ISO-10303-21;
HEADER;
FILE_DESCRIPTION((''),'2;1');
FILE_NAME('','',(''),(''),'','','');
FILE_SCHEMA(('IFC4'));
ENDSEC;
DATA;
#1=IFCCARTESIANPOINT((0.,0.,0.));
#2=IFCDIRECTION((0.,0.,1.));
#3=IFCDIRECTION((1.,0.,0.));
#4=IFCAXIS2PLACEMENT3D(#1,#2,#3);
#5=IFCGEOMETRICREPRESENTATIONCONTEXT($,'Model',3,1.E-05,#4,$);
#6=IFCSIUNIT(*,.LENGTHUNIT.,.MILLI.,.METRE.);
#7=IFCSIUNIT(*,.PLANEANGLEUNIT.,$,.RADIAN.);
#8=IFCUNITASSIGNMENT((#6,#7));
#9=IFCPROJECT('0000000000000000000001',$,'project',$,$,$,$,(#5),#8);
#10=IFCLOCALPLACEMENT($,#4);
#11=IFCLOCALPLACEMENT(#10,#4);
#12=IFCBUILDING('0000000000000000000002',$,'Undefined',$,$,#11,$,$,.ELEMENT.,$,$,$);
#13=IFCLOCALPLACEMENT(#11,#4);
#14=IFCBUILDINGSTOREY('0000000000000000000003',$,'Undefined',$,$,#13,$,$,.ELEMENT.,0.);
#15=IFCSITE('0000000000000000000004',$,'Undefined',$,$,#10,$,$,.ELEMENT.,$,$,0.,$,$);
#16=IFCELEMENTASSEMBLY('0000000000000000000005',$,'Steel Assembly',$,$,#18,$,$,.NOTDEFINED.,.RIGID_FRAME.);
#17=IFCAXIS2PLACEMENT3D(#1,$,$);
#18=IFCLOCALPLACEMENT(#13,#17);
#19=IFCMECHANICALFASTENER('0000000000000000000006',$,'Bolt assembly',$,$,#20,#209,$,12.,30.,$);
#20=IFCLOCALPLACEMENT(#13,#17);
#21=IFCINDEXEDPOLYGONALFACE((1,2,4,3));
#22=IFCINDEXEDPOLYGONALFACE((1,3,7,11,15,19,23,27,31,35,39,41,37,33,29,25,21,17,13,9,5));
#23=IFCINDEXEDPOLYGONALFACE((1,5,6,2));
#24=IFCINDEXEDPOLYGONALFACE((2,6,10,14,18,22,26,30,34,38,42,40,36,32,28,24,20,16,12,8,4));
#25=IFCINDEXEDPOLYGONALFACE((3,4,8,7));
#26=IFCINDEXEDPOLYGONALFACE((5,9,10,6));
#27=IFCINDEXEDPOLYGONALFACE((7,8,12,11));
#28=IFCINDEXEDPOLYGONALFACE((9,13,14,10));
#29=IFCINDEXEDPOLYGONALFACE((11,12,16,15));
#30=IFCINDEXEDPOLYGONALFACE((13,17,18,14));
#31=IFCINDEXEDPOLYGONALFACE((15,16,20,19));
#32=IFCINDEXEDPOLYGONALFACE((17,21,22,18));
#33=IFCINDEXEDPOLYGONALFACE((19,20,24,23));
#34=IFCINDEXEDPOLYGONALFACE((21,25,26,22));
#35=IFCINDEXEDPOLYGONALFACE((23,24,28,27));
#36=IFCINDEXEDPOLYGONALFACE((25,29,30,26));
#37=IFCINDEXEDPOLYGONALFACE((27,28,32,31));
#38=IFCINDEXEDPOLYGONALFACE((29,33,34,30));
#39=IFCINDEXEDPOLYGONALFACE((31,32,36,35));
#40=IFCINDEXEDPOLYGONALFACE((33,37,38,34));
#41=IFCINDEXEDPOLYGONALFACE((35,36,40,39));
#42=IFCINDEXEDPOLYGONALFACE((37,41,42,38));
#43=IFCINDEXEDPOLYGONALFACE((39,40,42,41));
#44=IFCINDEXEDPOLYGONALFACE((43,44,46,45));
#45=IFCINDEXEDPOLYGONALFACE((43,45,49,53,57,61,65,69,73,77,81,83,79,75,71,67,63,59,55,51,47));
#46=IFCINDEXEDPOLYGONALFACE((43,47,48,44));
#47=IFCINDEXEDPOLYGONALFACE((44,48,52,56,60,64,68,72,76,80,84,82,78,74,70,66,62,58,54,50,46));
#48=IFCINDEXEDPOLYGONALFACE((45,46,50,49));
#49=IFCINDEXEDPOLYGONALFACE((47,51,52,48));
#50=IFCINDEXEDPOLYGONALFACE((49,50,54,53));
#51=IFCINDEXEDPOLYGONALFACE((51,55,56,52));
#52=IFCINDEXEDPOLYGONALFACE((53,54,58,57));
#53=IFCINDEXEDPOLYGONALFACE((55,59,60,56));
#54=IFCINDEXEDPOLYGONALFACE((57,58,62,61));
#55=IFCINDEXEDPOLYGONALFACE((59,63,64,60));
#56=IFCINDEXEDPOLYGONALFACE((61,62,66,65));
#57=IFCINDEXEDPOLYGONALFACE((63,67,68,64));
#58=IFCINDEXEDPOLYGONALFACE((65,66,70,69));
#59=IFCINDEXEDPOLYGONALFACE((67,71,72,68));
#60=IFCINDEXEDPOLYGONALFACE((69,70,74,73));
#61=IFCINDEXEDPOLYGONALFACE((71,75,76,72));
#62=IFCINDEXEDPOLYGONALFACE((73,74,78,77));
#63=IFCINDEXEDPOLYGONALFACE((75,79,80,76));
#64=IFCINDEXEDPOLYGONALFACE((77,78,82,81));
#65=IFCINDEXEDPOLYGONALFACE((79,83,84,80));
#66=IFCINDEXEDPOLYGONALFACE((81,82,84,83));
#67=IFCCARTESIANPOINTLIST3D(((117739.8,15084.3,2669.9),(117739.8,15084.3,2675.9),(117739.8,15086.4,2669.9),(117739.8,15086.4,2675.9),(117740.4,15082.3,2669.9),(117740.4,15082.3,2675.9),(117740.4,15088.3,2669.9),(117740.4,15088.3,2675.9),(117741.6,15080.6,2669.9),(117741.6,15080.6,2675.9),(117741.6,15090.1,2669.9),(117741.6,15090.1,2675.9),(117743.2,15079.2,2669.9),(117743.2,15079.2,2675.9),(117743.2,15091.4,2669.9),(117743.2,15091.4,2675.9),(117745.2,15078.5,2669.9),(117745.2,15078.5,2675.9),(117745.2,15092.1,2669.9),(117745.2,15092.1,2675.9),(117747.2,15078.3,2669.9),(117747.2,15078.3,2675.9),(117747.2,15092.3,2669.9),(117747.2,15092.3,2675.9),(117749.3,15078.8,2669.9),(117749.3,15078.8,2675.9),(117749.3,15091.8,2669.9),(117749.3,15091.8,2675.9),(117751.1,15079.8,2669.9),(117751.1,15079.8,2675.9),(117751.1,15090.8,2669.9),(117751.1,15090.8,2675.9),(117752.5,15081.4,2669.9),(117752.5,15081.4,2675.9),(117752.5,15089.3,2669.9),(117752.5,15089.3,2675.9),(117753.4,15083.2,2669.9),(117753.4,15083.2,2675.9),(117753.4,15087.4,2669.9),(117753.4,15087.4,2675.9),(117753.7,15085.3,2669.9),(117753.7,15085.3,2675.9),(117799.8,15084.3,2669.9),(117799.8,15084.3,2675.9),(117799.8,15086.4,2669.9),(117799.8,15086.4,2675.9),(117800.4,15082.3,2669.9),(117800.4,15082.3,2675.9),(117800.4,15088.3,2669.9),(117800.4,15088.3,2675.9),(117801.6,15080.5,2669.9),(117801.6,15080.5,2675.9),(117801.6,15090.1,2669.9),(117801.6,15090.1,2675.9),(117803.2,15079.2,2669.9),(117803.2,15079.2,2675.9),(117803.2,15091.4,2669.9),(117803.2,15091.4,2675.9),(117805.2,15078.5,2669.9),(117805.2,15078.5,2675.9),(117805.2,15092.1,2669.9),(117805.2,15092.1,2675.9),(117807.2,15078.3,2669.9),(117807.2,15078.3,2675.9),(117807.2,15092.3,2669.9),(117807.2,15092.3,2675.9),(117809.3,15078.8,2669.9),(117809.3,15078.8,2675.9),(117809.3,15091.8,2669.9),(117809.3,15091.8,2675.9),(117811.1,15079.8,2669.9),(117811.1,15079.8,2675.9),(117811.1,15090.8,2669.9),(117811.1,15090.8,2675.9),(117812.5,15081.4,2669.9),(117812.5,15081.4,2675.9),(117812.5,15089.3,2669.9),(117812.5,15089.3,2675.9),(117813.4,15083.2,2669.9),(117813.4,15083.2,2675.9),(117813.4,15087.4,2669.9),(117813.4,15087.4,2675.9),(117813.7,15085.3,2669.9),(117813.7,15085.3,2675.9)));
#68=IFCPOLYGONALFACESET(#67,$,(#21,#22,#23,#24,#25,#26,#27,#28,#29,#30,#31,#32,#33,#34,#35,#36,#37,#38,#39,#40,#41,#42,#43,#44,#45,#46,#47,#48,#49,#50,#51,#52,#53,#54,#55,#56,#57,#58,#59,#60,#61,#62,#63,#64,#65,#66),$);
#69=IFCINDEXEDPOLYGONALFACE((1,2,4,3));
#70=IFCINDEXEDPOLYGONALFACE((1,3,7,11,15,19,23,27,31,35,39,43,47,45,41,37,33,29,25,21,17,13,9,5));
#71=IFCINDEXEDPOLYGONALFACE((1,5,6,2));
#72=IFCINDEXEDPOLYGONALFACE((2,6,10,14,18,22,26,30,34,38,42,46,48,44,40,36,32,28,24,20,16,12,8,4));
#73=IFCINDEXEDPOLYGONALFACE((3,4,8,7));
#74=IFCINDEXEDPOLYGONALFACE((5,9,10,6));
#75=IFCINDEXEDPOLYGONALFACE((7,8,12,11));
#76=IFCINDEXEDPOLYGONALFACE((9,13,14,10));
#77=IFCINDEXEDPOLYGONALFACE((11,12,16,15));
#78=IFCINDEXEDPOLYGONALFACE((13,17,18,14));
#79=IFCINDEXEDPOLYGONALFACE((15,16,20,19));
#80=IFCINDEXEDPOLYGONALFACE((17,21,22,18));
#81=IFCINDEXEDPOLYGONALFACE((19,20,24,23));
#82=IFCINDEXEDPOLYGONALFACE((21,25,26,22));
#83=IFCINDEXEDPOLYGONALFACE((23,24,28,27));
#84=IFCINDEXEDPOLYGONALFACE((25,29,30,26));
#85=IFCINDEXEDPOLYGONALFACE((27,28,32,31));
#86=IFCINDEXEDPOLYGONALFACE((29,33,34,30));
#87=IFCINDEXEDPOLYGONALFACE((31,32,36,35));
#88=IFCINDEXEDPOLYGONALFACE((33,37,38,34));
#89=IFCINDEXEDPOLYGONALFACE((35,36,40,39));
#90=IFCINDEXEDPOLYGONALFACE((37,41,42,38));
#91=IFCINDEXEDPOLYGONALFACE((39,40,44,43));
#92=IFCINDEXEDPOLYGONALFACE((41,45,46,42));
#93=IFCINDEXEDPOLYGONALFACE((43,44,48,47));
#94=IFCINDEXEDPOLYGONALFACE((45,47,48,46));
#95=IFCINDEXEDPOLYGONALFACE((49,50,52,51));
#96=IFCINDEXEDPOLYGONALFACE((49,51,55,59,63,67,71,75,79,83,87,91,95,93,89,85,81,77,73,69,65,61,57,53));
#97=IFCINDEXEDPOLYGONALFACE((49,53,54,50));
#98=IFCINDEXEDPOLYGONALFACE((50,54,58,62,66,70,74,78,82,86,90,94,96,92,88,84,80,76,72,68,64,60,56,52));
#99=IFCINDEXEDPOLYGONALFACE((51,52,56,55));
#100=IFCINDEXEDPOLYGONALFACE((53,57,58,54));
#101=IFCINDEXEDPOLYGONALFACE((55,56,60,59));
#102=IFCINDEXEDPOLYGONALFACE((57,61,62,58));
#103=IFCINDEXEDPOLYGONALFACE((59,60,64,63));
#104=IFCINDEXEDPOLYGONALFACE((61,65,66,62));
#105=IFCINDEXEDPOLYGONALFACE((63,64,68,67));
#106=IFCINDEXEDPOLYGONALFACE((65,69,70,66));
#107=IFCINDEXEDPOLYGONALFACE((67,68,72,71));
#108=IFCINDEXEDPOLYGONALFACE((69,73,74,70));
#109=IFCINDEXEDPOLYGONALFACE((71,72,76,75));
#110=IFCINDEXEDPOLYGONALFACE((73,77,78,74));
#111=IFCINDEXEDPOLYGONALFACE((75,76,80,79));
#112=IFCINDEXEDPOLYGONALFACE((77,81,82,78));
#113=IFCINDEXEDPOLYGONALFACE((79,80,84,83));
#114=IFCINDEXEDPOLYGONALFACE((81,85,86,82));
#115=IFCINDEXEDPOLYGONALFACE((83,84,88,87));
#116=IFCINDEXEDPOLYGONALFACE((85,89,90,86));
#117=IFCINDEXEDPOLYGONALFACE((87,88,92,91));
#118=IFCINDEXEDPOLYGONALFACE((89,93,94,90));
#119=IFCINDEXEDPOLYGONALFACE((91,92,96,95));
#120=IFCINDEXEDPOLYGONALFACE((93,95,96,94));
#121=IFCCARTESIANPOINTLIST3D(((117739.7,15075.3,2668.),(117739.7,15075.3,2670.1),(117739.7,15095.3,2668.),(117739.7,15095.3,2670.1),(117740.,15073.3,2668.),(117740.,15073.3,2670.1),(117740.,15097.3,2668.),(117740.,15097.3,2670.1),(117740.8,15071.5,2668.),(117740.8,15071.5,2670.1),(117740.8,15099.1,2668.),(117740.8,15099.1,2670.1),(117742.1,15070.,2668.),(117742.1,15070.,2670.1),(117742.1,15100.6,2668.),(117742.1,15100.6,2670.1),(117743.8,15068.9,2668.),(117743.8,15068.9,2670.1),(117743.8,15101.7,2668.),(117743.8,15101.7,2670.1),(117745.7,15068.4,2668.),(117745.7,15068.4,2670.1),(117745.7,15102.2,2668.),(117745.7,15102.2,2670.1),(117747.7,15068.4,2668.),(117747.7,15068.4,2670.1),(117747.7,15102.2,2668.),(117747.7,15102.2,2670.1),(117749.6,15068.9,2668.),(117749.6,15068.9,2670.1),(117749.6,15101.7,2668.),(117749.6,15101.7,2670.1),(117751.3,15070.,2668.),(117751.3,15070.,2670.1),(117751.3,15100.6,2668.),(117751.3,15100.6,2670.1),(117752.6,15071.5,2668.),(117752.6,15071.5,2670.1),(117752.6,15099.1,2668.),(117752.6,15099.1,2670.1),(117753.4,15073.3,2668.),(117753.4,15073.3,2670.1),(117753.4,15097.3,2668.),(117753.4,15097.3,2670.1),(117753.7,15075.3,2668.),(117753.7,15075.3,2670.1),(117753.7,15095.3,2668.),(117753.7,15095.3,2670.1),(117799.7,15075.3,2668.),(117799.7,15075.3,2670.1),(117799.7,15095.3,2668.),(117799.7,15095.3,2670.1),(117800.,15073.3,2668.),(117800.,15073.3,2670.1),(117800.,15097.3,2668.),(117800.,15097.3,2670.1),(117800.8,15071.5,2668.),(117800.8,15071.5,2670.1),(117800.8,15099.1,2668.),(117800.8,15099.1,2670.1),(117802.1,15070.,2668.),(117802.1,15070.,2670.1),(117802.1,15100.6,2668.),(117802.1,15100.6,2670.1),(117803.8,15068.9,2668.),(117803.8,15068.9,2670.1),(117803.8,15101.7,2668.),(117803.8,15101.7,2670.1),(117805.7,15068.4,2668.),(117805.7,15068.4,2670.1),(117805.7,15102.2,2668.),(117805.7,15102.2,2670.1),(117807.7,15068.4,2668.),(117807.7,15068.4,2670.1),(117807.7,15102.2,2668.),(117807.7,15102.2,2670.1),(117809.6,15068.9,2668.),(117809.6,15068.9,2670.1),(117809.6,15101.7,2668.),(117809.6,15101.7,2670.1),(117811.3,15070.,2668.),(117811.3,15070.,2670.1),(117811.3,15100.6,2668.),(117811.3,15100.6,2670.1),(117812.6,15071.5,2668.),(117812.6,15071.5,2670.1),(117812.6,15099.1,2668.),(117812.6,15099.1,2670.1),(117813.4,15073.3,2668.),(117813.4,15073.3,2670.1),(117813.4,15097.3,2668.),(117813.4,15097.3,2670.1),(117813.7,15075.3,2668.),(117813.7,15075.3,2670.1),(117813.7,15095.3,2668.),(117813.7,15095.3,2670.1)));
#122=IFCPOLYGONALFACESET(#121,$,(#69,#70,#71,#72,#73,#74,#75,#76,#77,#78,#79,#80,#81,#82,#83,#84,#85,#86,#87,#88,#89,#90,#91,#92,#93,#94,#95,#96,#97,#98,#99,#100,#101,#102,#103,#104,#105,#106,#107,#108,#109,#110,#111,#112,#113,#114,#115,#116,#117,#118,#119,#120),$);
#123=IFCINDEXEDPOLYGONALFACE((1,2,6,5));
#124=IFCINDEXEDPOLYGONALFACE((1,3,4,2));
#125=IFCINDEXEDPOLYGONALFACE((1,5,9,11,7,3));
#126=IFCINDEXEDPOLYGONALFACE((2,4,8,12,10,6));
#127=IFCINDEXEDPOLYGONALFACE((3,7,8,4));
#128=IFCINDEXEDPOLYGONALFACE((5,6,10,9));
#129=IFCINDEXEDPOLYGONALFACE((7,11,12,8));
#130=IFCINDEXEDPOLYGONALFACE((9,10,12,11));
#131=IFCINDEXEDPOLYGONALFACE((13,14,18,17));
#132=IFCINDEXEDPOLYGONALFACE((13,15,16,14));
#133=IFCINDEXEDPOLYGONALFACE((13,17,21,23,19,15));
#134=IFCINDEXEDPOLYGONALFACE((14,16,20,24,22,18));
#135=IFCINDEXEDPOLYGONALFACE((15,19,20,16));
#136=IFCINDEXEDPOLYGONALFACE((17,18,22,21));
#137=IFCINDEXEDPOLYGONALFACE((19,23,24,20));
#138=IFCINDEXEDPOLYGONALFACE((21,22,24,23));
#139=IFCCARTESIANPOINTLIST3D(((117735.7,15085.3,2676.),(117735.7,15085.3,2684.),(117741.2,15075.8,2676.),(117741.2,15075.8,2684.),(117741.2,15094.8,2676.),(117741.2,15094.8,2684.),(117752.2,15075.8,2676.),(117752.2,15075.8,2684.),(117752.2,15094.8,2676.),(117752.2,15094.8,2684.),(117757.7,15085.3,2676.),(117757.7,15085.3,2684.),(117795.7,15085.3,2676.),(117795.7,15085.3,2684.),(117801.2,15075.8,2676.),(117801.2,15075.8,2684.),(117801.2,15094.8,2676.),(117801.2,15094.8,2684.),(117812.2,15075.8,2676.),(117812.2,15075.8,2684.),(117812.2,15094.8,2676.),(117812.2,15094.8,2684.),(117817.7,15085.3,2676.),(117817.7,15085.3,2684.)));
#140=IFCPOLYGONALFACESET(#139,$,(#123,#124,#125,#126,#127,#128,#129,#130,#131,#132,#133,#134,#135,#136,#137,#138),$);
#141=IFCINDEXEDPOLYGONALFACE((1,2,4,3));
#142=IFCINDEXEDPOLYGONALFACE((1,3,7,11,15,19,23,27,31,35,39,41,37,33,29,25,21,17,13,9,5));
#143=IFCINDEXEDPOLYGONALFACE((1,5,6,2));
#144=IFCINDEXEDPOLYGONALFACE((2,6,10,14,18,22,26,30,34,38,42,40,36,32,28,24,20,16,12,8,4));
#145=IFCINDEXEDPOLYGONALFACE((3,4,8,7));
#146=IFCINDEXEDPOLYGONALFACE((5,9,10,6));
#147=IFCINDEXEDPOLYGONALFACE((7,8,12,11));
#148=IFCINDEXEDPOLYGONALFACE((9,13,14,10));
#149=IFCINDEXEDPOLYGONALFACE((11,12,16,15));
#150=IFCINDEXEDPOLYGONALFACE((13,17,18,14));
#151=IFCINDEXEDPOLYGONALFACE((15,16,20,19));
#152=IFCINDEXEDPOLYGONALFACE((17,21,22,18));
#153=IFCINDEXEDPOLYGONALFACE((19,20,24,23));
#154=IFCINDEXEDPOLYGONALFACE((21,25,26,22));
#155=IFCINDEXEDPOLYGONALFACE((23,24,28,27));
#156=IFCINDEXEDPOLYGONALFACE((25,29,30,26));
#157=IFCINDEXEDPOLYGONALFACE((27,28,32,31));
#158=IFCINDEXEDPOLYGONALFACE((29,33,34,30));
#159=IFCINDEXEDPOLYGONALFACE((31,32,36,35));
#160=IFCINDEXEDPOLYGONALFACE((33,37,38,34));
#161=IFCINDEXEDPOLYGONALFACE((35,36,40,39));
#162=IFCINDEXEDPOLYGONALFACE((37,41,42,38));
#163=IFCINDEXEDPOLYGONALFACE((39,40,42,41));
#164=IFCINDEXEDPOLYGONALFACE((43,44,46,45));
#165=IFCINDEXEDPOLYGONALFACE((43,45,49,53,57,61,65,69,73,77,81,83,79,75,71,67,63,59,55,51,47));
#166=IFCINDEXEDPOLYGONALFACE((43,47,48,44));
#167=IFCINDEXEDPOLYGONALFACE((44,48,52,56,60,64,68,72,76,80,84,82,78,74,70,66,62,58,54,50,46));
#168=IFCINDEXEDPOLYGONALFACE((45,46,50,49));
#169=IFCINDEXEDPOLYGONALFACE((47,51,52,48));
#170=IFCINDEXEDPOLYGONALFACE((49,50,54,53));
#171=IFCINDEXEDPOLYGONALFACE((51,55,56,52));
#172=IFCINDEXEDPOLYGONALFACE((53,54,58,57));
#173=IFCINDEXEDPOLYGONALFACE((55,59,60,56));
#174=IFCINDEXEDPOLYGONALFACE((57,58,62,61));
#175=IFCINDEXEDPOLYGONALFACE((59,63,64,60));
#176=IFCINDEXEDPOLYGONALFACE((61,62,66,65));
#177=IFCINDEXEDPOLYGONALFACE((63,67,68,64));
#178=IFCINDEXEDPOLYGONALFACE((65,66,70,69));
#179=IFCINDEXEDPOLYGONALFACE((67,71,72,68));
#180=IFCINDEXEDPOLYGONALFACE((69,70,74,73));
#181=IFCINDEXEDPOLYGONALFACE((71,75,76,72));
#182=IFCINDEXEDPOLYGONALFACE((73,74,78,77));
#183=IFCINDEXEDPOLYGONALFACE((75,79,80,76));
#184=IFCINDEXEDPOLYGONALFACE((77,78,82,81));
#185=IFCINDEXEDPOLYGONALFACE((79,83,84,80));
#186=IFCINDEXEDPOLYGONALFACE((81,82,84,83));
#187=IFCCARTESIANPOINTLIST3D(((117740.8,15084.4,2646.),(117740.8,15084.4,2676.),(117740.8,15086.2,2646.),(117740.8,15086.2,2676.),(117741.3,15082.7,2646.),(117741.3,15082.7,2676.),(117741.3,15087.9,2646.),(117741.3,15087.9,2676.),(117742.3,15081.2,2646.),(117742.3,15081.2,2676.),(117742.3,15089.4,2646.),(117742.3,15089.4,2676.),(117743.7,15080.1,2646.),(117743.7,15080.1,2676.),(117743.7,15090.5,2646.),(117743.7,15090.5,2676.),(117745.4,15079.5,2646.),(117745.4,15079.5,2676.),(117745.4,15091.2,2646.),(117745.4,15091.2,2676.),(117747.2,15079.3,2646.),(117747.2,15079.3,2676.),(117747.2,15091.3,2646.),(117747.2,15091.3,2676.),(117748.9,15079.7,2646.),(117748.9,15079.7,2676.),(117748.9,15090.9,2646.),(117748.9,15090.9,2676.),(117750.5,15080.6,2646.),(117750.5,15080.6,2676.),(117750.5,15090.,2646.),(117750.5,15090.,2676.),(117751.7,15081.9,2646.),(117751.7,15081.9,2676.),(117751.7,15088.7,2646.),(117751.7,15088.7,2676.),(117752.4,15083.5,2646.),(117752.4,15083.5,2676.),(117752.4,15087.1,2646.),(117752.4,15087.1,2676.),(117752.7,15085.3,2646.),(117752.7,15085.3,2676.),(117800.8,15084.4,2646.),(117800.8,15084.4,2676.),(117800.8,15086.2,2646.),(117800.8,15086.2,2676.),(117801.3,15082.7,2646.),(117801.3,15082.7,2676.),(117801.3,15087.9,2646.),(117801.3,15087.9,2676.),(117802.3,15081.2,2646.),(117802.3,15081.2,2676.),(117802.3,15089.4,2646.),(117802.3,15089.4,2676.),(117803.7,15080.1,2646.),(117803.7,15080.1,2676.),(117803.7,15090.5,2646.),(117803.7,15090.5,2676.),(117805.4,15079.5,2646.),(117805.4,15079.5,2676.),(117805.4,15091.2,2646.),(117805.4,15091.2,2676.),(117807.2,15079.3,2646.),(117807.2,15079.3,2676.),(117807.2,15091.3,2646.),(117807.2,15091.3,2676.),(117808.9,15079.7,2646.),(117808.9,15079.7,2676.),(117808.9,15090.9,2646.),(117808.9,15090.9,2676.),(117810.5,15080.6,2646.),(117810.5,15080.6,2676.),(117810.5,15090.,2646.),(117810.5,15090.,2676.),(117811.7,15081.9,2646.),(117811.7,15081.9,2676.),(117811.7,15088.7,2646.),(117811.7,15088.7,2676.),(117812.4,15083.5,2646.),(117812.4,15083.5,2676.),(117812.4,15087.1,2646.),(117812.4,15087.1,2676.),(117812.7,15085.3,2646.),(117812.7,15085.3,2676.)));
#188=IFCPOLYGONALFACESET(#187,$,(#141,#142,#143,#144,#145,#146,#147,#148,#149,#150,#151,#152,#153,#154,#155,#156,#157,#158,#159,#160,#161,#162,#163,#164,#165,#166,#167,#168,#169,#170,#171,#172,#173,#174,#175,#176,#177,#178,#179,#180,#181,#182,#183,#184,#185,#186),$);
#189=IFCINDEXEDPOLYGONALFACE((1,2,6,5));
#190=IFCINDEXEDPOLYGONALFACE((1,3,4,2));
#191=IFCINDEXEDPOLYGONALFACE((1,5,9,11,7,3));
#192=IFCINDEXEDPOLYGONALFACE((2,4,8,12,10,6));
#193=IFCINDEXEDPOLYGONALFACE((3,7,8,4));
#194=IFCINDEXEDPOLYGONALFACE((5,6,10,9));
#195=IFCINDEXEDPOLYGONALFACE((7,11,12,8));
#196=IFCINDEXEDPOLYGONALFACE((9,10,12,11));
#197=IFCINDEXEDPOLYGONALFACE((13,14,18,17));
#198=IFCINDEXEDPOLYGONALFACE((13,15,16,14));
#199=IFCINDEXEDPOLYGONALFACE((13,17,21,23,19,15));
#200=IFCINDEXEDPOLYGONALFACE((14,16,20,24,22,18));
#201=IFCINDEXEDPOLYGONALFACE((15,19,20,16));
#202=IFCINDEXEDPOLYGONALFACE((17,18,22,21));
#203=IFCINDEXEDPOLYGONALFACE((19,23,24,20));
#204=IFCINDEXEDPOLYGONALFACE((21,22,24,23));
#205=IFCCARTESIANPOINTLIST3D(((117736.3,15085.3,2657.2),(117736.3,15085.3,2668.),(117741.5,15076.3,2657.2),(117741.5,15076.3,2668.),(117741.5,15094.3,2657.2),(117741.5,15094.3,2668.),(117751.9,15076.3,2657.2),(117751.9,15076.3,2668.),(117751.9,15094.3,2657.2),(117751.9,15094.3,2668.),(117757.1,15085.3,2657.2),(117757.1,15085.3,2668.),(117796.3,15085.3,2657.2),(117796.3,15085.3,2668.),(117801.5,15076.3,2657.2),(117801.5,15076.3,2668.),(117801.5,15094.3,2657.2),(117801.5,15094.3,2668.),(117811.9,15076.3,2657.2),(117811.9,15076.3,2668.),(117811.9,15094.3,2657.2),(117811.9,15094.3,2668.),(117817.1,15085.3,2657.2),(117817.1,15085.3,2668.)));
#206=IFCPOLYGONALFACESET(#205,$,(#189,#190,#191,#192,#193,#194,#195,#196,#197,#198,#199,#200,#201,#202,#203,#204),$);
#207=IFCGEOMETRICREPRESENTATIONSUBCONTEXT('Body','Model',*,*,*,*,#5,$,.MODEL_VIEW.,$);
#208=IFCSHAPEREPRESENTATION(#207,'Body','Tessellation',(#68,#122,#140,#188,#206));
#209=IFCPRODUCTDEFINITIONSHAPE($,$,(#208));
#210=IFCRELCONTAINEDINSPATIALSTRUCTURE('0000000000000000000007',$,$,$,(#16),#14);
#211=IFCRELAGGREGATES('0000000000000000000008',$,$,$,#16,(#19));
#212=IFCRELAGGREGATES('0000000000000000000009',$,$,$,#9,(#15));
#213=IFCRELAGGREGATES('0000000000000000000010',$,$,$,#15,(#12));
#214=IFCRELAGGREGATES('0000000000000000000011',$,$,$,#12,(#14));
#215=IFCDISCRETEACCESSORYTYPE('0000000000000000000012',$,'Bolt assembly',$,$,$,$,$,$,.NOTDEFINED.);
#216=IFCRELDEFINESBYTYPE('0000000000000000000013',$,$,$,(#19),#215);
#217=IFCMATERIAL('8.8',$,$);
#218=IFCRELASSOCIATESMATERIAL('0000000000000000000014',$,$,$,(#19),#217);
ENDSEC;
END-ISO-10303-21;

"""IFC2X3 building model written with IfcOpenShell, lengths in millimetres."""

from ifc_helpers import new_model, si_unit, frame, frame_2d, origin_with_axes, origin_2d_with_axis, place, context, subcontext, project, spatial, polyline, circle_curve, parameter, trimmed, segment, composite_curve, circle, outline, extrude, source, transform, mapped, material, type_object, element, aggregate, save


model = new_model("IFC2X3")

# Units and contexts
model_context = context("Model", 3, precision=1e-05, world=origin_with_axes())
body_context = subcontext(model_context, "Body", "Model", "MODEL_VIEW")
ifc_project = project(units=[si_unit("LENGTHUNIT", "METRE", prefix="MILLI"), si_unit("PLANEANGLEUNIT", "RADIAN")], contexts=[model_context])

# Site, building, storey
site_placement = place(None, origin_with_axes())
site = spatial("IfcSite", under=ifc_project, at=site_placement, Name="Undefined", CompositionType="ELEMENT", RefElevation=0.0)
building_placement = place(site_placement, origin_with_axes())
building = spatial("IfcBuilding", under=site, at=building_placement, Name="Undefined", CompositionType="ELEMENT")
storey_placement = place(building_placement, origin_with_axes())
storey = spatial("IfcBuildingStorey", under=building, at=storey_placement, Name="Undefined", CompositionType="ELEMENT", Elevation=0.0)

# Shared definitions
ifc_material_1 = material(Name="8.8")
discrete_accessory_type_1 = type_object("IfcDiscreteAccessoryType", Name="Bolt assembly")

# Element assembly, mechanical fastener
assembly_1_placement = place(storey_placement, origin_with_axes())
assembly_1 = element("IfcElementAssembly", 1, at=assembly_1_placement, inside=storey, Name="Steel Assembly", AssemblyPlace="NOTDEFINED", PredefinedType="RIGID_FRAME")
shared_shape_1 = source(origin_with_axes(), body_context, "Body", "SweptSolid", [
    extrude(circle(Radius=7.0, at=origin_2d_with_axis()), frame((0.0, -2.9, 0.0), z_axis=(0.0, 1.0, 0.0), x_axis=(1.0, 0.0, 0.0)), (0.0, 0.0, 1.0), 6.0),
    extrude(outline(composite_curve([segment(polyline([(7.0, 10.0), (7.0, -10.0)]), True, "CONTINUOUS"), segment(trimmed(circle_curve(frame_2d((0.0, -10.0), x_axis=(1.0, 0.0)), 7.0), [parameter(0.0)], [parameter(3.1416)], False, "PARAMETER"), True, "CONTINUOUS"), segment(polyline([(-7.0, -10.0), (-7.0, 10.0)]), True, "CONTINUOUS"), segment(trimmed(circle_curve(frame_2d((0.0, 10.0), x_axis=(-1.0, 0.0)), 7.0), [parameter(0.0)], [parameter(3.1416)], False, "PARAMETER"), True, "DISCONTINUOUS")], self_intersect=False)), frame((0.0, 2.9, 0.0), z_axis=(0.0, 1.0, 0.0), x_axis=(1.0, 0.0, 0.0)), (0.0, 0.0, 1.0), 2.1),
    extrude(outline(polyline([(11.0, 0.0), (5.5, 9.5), (-5.5, 9.5), (-11.0, 0.0), (-5.5, -9.5), (5.5, -9.5), (11.0, 0.0)])), frame((0.0, -11.0, 0.0), z_axis=(0.0, 1.0, 0.0), x_axis=(1.0, 0.0, 0.0)), (0.0, 0.0, 1.0), 8.0),
    extrude(circle(Radius=6.0, at=origin_2d_with_axis()), frame((0.0, -3.0, 0.0), z_axis=(0.0, 1.0, 0.0), x_axis=(1.0, 0.0, 0.0)), (0.0, 0.0, 1.0), 30.0),
    extrude(outline(polyline([(10.4, 0.0), (5.2, 9.0), (-5.2, 9.0), (-10.4, 0.0), (-5.2, -9.0), (5.2, -9.0), (10.4, 0.0)])), frame((0.0, 5.0, 0.0), z_axis=(0.0, 1.0, 0.0), x_axis=(1.0, 0.0, 0.0)), (0.0, 0.0, 1.0), 10.8),
])
mechanical_fastener_1_placement = place(assembly_1_placement, frame((117701.7, 15040.3, 2673.0), z_axis=(0.000045, 1.0, 0.0), x_axis=(1.0, -0.000045, 0.0)))
mechanical_fastener_1 = element("IfcMechanicalFastener", 2, at=mechanical_fastener_1_placement, type_object=discrete_accessory_type_1, material=ifc_material_1, Name="Bolt assembly", NominalDiameter=12.0, NominalLength=30.0, context=body_context, shape_type="MappedRepresentation", body=[
    mapped(shared_shape_1, transform((45.0, 0.0, 45.0))),
    mapped(shared_shape_1, transform((105.0, 0.0, 45.0))),
])
aggregate(assembly_1, [mechanical_fastener_1])

save(model, "model.ifc")
